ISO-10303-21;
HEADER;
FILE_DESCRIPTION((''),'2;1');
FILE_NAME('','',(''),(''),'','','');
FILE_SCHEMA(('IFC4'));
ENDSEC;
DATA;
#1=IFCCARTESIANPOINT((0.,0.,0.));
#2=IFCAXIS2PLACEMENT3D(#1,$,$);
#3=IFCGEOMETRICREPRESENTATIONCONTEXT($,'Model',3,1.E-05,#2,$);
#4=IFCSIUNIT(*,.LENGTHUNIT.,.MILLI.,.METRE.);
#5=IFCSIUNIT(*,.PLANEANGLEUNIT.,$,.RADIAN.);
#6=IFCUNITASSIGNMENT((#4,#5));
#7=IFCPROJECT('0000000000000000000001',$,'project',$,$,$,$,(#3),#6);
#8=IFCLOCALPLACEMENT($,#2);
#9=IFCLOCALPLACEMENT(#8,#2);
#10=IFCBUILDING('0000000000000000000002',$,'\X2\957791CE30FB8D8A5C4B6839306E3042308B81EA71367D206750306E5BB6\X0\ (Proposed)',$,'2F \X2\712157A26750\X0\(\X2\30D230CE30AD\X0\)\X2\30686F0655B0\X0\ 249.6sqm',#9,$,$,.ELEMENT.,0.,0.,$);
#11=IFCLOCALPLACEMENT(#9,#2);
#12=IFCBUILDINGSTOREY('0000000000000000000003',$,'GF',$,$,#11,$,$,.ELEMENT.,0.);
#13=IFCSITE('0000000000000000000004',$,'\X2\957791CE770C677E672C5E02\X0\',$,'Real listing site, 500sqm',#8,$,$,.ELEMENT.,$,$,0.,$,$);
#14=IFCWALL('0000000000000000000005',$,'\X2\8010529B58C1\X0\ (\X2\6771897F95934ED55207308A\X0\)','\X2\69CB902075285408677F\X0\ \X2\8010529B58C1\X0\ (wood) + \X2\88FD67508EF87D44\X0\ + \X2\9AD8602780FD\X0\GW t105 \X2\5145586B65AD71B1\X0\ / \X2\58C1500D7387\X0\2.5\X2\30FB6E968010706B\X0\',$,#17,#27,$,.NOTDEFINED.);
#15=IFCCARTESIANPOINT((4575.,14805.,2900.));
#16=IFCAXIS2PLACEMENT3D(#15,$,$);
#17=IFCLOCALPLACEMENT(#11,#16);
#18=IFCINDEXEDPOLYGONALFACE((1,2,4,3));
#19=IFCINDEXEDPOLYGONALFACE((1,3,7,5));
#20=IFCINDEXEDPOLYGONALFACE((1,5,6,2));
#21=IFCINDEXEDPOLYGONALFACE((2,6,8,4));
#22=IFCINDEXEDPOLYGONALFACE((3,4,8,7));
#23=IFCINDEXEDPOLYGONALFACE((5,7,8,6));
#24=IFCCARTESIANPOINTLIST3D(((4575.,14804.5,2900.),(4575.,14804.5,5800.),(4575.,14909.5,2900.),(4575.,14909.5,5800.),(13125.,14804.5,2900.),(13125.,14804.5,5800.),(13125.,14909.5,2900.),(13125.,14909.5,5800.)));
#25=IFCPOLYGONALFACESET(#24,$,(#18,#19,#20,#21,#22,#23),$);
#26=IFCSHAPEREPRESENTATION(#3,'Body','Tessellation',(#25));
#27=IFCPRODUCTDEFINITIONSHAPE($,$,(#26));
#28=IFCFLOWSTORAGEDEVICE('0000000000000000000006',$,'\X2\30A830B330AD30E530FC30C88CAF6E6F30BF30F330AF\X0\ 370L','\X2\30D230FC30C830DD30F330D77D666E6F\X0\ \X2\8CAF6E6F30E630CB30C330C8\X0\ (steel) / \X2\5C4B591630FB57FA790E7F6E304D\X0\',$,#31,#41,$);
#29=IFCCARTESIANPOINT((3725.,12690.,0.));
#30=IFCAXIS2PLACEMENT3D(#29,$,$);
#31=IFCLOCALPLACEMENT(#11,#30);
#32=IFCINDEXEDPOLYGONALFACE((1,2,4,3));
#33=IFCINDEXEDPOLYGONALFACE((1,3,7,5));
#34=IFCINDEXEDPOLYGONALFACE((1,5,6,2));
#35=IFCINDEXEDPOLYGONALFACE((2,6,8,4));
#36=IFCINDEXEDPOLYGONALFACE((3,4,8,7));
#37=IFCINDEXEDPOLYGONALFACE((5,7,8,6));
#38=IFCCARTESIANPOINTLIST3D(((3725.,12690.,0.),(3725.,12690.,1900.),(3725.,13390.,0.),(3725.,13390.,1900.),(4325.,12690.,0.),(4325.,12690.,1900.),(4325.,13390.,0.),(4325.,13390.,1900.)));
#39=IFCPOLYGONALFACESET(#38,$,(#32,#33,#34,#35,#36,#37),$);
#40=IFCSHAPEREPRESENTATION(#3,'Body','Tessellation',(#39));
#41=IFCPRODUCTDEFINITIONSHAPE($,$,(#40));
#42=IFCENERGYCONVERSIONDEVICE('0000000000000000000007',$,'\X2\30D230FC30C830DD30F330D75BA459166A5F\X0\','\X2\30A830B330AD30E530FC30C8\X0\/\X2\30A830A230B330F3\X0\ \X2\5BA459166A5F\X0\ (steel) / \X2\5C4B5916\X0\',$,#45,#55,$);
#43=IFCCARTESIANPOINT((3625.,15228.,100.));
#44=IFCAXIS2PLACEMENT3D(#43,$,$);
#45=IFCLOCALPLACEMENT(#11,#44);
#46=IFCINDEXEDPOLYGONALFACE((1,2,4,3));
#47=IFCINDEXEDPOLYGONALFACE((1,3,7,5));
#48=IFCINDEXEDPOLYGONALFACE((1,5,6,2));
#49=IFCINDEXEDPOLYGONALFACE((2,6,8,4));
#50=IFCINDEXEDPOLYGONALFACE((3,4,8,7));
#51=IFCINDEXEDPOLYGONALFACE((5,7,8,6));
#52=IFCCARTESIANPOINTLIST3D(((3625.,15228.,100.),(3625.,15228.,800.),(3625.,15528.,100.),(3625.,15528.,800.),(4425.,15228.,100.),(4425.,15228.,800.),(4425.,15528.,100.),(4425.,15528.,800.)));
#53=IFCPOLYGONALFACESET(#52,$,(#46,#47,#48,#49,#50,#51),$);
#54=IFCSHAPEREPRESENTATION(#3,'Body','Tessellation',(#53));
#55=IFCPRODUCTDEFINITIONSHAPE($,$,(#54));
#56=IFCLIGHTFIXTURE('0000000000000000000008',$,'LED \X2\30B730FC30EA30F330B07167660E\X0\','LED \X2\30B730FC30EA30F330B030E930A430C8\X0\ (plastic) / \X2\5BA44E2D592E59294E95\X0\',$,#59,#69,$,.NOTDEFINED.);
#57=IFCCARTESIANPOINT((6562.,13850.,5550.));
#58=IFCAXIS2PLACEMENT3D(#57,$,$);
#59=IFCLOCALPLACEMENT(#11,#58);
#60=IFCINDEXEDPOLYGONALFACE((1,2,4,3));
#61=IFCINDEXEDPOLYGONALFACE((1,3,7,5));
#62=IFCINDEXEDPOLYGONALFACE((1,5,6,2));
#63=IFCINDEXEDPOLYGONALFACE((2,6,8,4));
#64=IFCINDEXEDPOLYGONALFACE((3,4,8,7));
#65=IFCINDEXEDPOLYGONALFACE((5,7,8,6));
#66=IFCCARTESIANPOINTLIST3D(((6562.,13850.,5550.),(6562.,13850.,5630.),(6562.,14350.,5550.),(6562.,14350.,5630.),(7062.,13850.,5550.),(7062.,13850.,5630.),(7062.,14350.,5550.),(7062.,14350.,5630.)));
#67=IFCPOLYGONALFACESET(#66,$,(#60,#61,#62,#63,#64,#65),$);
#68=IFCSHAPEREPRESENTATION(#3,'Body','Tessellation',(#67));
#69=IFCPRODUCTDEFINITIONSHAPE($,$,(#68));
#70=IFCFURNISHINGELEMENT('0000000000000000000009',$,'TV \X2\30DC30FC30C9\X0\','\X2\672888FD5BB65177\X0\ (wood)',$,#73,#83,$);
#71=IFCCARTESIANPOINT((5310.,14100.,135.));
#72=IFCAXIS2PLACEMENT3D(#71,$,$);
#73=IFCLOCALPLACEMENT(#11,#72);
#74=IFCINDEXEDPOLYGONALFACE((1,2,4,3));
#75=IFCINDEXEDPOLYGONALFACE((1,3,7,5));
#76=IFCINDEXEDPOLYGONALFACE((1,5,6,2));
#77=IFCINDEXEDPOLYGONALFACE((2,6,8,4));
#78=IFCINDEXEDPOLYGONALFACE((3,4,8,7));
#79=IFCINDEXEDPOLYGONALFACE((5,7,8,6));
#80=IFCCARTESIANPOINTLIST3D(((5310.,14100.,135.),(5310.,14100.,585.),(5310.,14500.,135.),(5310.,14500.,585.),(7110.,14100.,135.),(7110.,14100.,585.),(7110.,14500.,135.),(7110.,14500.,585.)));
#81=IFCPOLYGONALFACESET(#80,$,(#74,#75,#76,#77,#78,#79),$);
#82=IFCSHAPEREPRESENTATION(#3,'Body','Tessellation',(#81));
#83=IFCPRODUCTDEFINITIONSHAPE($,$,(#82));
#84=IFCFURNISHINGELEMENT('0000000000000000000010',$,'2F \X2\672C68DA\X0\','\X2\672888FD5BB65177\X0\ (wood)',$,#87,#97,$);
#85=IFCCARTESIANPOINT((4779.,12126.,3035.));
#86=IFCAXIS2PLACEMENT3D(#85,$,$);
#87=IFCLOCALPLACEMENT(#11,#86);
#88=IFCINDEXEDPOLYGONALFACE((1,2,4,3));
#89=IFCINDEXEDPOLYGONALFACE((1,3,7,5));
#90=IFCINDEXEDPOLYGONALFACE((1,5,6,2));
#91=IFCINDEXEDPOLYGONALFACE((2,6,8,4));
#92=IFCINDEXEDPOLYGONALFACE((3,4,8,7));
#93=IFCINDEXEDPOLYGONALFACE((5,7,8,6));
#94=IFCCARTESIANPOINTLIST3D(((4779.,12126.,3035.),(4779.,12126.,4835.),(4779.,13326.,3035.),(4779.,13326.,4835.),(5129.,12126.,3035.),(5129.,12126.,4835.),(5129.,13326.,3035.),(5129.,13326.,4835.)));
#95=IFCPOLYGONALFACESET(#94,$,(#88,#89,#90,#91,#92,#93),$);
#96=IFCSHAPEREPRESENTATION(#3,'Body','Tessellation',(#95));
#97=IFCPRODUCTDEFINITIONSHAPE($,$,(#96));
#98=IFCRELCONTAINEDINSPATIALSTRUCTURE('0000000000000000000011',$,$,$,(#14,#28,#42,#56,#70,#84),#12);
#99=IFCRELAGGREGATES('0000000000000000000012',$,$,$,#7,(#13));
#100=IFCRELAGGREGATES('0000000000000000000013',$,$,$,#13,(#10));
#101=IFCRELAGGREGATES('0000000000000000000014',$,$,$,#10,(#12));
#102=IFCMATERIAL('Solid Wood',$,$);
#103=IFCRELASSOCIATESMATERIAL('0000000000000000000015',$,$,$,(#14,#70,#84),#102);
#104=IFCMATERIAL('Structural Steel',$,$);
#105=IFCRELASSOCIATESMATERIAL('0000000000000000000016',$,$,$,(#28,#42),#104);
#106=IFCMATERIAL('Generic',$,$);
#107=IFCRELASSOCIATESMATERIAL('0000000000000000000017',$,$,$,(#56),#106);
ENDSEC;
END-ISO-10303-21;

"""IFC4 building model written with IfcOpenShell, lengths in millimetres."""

from ifc_helpers import new_model, si_unit, frame, frame_2d, origin, place, context, project, spatial, rectangle, extrude, material, element, save


model = new_model("IFC4")

# Units and contexts
model_context = context("Model", 3, precision=1e-05, world=origin())
ifc_project = project(units=[si_unit("LENGTHUNIT", "METRE", prefix="MILLI"), si_unit("PLANEANGLEUNIT", "RADIAN")], contexts=[model_context])

# Site, building, storey
site_placement = place(None, origin())
site = spatial("IfcSite", under=ifc_project, at=site_placement, Name="長野県松本市", ObjectType="Real listing site, 500sqm", CompositionType="ELEMENT", RefElevation=0.0)
building_placement = place(site_placement, origin())
building = spatial("IfcBuilding", under=site, at=building_placement, Name="長野・越屋根のある自然素材の家 (Proposed)", ObjectType="2F 無垢材(ヒノキ)と漆喰 249.6sqm", CompositionType="ELEMENT", ElevationOfRefHeight=0.0, ElevationOfTerrain=0.0)
storey_placement = place(building_placement, origin())
storey = spatial("IfcBuildingStorey", under=building, at=storey_placement, Name="GF", CompositionType="ELEMENT", Elevation=0.0)

# Shared definitions
ifc_material_1 = material(Name="Solid Wood")

# Wall
wall_1_placement = place(storey_placement, frame((4575.0, 14805.0, 2900.0)))
element("IfcWall", 1, at=wall_1_placement, inside=storey, material=ifc_material_1, Name="耐力壁 (東西間仕切り)", Description="構造用合板 耐力壁 (wood) + 製材軸組 + 高性能GW t105 充填断熱 / 壁倍率2.5・準耐火", PredefinedType="NOTDEFINED", context=model_context, shape_type="SweptSolid", body=[
    extrude(rectangle(XDim=8550.0, YDim=105.0, at=frame_2d((4275.0, 52.0))), frame((4575.0, 14805.0, 2900.0)), (0.0, 0.0, 1.0), 2900.0),
])

# Flow storage device
ifc_material_2 = material(Name="Structural Steel")
flow_storage_device_placement = place(storey_placement, frame((3725.0, 12690.0, 0.0)))
element("IfcFlowStorageDevice", 2, at=flow_storage_device_placement, inside=storey, material=ifc_material_2, Name="エコキュート貯湯タンク 370L", Description="ヒートポンプ給湯 貯湯ユニット (steel) / 屋外・基礎置き", context=model_context, shape_type="SweptSolid", body=[
    extrude(rectangle(XDim=600.0, YDim=700.0, at=frame_2d((300.0, 350.0))), frame((3725.0, 12690.0, 0.0)), (0.0, 0.0, 1.0), 1900.0),
])

# Energy conversion device
energy_conversion_device_placement = place(storey_placement, frame((3625.0, 15228.0, 100.0)))
element("IfcEnergyConversionDevice", 3, at=energy_conversion_device_placement, inside=storey, material=ifc_material_2, Name="ヒートポンプ室外機", Description="エコキュート/エアコン 室外機 (steel) / 屋外", context=model_context, shape_type="SweptSolid", body=[
    extrude(rectangle(XDim=800.0, YDim=300.0, at=frame_2d((400.0, 150.0))), frame((3625.0, 15228.0, 100.0)), (0.0, 0.0, 1.0), 700.0),
])

# Light fixture
ifc_material_3 = material(Name="Generic")
light_fixture_placement = place(storey_placement, frame((6562.0, 13850.0, 5550.0)))
element("IfcLightFixture", 4, at=light_fixture_placement, inside=storey, material=ifc_material_3, Name="LED シーリング照明", Description="LED シーリングライト (plastic) / 室中央天井", PredefinedType="NOTDEFINED", context=model_context, shape_type="SweptSolid", body=[
    extrude(rectangle(XDim=500.0, YDim=500.0, at=frame_2d((250.0, 250.0))), frame((6562.0, 13850.0, 5550.0)), (0.0, 0.0, 1.0), 80.0),
])

# Furnishing elements
furnishing_1_placement = place(storey_placement, frame((5310.0, 14100.0, 135.0)))
element("IfcFurnishingElement", 5, at=furnishing_1_placement, inside=storey, material=ifc_material_1, Name="TV ボード", Description="木製家具 (wood)", context=model_context, shape_type="SweptSolid", body=[
    extrude(rectangle(XDim=1800.0, YDim=400.0, at=frame_2d((900.0, 200.0))), frame((5310.0, 14100.0, 135.0)), (0.0, 0.0, 1.0), 450.0),
])
furnishing_2_placement = place(storey_placement, frame((4779.0, 12126.0, 3035.0)))
element("IfcFurnishingElement", 6, at=furnishing_2_placement, inside=storey, material=ifc_material_1, Name="2F 本棚", Description="木製家具 (wood)", context=model_context, shape_type="SweptSolid", body=[
    extrude(rectangle(XDim=350.0, YDim=1200.0, at=frame_2d((175.0, 600.0))), frame((4779.0, 12126.0, 3035.0)), (0.0, 0.0, 1.0), 1800.0),
])

save(model, "model.ifc")
